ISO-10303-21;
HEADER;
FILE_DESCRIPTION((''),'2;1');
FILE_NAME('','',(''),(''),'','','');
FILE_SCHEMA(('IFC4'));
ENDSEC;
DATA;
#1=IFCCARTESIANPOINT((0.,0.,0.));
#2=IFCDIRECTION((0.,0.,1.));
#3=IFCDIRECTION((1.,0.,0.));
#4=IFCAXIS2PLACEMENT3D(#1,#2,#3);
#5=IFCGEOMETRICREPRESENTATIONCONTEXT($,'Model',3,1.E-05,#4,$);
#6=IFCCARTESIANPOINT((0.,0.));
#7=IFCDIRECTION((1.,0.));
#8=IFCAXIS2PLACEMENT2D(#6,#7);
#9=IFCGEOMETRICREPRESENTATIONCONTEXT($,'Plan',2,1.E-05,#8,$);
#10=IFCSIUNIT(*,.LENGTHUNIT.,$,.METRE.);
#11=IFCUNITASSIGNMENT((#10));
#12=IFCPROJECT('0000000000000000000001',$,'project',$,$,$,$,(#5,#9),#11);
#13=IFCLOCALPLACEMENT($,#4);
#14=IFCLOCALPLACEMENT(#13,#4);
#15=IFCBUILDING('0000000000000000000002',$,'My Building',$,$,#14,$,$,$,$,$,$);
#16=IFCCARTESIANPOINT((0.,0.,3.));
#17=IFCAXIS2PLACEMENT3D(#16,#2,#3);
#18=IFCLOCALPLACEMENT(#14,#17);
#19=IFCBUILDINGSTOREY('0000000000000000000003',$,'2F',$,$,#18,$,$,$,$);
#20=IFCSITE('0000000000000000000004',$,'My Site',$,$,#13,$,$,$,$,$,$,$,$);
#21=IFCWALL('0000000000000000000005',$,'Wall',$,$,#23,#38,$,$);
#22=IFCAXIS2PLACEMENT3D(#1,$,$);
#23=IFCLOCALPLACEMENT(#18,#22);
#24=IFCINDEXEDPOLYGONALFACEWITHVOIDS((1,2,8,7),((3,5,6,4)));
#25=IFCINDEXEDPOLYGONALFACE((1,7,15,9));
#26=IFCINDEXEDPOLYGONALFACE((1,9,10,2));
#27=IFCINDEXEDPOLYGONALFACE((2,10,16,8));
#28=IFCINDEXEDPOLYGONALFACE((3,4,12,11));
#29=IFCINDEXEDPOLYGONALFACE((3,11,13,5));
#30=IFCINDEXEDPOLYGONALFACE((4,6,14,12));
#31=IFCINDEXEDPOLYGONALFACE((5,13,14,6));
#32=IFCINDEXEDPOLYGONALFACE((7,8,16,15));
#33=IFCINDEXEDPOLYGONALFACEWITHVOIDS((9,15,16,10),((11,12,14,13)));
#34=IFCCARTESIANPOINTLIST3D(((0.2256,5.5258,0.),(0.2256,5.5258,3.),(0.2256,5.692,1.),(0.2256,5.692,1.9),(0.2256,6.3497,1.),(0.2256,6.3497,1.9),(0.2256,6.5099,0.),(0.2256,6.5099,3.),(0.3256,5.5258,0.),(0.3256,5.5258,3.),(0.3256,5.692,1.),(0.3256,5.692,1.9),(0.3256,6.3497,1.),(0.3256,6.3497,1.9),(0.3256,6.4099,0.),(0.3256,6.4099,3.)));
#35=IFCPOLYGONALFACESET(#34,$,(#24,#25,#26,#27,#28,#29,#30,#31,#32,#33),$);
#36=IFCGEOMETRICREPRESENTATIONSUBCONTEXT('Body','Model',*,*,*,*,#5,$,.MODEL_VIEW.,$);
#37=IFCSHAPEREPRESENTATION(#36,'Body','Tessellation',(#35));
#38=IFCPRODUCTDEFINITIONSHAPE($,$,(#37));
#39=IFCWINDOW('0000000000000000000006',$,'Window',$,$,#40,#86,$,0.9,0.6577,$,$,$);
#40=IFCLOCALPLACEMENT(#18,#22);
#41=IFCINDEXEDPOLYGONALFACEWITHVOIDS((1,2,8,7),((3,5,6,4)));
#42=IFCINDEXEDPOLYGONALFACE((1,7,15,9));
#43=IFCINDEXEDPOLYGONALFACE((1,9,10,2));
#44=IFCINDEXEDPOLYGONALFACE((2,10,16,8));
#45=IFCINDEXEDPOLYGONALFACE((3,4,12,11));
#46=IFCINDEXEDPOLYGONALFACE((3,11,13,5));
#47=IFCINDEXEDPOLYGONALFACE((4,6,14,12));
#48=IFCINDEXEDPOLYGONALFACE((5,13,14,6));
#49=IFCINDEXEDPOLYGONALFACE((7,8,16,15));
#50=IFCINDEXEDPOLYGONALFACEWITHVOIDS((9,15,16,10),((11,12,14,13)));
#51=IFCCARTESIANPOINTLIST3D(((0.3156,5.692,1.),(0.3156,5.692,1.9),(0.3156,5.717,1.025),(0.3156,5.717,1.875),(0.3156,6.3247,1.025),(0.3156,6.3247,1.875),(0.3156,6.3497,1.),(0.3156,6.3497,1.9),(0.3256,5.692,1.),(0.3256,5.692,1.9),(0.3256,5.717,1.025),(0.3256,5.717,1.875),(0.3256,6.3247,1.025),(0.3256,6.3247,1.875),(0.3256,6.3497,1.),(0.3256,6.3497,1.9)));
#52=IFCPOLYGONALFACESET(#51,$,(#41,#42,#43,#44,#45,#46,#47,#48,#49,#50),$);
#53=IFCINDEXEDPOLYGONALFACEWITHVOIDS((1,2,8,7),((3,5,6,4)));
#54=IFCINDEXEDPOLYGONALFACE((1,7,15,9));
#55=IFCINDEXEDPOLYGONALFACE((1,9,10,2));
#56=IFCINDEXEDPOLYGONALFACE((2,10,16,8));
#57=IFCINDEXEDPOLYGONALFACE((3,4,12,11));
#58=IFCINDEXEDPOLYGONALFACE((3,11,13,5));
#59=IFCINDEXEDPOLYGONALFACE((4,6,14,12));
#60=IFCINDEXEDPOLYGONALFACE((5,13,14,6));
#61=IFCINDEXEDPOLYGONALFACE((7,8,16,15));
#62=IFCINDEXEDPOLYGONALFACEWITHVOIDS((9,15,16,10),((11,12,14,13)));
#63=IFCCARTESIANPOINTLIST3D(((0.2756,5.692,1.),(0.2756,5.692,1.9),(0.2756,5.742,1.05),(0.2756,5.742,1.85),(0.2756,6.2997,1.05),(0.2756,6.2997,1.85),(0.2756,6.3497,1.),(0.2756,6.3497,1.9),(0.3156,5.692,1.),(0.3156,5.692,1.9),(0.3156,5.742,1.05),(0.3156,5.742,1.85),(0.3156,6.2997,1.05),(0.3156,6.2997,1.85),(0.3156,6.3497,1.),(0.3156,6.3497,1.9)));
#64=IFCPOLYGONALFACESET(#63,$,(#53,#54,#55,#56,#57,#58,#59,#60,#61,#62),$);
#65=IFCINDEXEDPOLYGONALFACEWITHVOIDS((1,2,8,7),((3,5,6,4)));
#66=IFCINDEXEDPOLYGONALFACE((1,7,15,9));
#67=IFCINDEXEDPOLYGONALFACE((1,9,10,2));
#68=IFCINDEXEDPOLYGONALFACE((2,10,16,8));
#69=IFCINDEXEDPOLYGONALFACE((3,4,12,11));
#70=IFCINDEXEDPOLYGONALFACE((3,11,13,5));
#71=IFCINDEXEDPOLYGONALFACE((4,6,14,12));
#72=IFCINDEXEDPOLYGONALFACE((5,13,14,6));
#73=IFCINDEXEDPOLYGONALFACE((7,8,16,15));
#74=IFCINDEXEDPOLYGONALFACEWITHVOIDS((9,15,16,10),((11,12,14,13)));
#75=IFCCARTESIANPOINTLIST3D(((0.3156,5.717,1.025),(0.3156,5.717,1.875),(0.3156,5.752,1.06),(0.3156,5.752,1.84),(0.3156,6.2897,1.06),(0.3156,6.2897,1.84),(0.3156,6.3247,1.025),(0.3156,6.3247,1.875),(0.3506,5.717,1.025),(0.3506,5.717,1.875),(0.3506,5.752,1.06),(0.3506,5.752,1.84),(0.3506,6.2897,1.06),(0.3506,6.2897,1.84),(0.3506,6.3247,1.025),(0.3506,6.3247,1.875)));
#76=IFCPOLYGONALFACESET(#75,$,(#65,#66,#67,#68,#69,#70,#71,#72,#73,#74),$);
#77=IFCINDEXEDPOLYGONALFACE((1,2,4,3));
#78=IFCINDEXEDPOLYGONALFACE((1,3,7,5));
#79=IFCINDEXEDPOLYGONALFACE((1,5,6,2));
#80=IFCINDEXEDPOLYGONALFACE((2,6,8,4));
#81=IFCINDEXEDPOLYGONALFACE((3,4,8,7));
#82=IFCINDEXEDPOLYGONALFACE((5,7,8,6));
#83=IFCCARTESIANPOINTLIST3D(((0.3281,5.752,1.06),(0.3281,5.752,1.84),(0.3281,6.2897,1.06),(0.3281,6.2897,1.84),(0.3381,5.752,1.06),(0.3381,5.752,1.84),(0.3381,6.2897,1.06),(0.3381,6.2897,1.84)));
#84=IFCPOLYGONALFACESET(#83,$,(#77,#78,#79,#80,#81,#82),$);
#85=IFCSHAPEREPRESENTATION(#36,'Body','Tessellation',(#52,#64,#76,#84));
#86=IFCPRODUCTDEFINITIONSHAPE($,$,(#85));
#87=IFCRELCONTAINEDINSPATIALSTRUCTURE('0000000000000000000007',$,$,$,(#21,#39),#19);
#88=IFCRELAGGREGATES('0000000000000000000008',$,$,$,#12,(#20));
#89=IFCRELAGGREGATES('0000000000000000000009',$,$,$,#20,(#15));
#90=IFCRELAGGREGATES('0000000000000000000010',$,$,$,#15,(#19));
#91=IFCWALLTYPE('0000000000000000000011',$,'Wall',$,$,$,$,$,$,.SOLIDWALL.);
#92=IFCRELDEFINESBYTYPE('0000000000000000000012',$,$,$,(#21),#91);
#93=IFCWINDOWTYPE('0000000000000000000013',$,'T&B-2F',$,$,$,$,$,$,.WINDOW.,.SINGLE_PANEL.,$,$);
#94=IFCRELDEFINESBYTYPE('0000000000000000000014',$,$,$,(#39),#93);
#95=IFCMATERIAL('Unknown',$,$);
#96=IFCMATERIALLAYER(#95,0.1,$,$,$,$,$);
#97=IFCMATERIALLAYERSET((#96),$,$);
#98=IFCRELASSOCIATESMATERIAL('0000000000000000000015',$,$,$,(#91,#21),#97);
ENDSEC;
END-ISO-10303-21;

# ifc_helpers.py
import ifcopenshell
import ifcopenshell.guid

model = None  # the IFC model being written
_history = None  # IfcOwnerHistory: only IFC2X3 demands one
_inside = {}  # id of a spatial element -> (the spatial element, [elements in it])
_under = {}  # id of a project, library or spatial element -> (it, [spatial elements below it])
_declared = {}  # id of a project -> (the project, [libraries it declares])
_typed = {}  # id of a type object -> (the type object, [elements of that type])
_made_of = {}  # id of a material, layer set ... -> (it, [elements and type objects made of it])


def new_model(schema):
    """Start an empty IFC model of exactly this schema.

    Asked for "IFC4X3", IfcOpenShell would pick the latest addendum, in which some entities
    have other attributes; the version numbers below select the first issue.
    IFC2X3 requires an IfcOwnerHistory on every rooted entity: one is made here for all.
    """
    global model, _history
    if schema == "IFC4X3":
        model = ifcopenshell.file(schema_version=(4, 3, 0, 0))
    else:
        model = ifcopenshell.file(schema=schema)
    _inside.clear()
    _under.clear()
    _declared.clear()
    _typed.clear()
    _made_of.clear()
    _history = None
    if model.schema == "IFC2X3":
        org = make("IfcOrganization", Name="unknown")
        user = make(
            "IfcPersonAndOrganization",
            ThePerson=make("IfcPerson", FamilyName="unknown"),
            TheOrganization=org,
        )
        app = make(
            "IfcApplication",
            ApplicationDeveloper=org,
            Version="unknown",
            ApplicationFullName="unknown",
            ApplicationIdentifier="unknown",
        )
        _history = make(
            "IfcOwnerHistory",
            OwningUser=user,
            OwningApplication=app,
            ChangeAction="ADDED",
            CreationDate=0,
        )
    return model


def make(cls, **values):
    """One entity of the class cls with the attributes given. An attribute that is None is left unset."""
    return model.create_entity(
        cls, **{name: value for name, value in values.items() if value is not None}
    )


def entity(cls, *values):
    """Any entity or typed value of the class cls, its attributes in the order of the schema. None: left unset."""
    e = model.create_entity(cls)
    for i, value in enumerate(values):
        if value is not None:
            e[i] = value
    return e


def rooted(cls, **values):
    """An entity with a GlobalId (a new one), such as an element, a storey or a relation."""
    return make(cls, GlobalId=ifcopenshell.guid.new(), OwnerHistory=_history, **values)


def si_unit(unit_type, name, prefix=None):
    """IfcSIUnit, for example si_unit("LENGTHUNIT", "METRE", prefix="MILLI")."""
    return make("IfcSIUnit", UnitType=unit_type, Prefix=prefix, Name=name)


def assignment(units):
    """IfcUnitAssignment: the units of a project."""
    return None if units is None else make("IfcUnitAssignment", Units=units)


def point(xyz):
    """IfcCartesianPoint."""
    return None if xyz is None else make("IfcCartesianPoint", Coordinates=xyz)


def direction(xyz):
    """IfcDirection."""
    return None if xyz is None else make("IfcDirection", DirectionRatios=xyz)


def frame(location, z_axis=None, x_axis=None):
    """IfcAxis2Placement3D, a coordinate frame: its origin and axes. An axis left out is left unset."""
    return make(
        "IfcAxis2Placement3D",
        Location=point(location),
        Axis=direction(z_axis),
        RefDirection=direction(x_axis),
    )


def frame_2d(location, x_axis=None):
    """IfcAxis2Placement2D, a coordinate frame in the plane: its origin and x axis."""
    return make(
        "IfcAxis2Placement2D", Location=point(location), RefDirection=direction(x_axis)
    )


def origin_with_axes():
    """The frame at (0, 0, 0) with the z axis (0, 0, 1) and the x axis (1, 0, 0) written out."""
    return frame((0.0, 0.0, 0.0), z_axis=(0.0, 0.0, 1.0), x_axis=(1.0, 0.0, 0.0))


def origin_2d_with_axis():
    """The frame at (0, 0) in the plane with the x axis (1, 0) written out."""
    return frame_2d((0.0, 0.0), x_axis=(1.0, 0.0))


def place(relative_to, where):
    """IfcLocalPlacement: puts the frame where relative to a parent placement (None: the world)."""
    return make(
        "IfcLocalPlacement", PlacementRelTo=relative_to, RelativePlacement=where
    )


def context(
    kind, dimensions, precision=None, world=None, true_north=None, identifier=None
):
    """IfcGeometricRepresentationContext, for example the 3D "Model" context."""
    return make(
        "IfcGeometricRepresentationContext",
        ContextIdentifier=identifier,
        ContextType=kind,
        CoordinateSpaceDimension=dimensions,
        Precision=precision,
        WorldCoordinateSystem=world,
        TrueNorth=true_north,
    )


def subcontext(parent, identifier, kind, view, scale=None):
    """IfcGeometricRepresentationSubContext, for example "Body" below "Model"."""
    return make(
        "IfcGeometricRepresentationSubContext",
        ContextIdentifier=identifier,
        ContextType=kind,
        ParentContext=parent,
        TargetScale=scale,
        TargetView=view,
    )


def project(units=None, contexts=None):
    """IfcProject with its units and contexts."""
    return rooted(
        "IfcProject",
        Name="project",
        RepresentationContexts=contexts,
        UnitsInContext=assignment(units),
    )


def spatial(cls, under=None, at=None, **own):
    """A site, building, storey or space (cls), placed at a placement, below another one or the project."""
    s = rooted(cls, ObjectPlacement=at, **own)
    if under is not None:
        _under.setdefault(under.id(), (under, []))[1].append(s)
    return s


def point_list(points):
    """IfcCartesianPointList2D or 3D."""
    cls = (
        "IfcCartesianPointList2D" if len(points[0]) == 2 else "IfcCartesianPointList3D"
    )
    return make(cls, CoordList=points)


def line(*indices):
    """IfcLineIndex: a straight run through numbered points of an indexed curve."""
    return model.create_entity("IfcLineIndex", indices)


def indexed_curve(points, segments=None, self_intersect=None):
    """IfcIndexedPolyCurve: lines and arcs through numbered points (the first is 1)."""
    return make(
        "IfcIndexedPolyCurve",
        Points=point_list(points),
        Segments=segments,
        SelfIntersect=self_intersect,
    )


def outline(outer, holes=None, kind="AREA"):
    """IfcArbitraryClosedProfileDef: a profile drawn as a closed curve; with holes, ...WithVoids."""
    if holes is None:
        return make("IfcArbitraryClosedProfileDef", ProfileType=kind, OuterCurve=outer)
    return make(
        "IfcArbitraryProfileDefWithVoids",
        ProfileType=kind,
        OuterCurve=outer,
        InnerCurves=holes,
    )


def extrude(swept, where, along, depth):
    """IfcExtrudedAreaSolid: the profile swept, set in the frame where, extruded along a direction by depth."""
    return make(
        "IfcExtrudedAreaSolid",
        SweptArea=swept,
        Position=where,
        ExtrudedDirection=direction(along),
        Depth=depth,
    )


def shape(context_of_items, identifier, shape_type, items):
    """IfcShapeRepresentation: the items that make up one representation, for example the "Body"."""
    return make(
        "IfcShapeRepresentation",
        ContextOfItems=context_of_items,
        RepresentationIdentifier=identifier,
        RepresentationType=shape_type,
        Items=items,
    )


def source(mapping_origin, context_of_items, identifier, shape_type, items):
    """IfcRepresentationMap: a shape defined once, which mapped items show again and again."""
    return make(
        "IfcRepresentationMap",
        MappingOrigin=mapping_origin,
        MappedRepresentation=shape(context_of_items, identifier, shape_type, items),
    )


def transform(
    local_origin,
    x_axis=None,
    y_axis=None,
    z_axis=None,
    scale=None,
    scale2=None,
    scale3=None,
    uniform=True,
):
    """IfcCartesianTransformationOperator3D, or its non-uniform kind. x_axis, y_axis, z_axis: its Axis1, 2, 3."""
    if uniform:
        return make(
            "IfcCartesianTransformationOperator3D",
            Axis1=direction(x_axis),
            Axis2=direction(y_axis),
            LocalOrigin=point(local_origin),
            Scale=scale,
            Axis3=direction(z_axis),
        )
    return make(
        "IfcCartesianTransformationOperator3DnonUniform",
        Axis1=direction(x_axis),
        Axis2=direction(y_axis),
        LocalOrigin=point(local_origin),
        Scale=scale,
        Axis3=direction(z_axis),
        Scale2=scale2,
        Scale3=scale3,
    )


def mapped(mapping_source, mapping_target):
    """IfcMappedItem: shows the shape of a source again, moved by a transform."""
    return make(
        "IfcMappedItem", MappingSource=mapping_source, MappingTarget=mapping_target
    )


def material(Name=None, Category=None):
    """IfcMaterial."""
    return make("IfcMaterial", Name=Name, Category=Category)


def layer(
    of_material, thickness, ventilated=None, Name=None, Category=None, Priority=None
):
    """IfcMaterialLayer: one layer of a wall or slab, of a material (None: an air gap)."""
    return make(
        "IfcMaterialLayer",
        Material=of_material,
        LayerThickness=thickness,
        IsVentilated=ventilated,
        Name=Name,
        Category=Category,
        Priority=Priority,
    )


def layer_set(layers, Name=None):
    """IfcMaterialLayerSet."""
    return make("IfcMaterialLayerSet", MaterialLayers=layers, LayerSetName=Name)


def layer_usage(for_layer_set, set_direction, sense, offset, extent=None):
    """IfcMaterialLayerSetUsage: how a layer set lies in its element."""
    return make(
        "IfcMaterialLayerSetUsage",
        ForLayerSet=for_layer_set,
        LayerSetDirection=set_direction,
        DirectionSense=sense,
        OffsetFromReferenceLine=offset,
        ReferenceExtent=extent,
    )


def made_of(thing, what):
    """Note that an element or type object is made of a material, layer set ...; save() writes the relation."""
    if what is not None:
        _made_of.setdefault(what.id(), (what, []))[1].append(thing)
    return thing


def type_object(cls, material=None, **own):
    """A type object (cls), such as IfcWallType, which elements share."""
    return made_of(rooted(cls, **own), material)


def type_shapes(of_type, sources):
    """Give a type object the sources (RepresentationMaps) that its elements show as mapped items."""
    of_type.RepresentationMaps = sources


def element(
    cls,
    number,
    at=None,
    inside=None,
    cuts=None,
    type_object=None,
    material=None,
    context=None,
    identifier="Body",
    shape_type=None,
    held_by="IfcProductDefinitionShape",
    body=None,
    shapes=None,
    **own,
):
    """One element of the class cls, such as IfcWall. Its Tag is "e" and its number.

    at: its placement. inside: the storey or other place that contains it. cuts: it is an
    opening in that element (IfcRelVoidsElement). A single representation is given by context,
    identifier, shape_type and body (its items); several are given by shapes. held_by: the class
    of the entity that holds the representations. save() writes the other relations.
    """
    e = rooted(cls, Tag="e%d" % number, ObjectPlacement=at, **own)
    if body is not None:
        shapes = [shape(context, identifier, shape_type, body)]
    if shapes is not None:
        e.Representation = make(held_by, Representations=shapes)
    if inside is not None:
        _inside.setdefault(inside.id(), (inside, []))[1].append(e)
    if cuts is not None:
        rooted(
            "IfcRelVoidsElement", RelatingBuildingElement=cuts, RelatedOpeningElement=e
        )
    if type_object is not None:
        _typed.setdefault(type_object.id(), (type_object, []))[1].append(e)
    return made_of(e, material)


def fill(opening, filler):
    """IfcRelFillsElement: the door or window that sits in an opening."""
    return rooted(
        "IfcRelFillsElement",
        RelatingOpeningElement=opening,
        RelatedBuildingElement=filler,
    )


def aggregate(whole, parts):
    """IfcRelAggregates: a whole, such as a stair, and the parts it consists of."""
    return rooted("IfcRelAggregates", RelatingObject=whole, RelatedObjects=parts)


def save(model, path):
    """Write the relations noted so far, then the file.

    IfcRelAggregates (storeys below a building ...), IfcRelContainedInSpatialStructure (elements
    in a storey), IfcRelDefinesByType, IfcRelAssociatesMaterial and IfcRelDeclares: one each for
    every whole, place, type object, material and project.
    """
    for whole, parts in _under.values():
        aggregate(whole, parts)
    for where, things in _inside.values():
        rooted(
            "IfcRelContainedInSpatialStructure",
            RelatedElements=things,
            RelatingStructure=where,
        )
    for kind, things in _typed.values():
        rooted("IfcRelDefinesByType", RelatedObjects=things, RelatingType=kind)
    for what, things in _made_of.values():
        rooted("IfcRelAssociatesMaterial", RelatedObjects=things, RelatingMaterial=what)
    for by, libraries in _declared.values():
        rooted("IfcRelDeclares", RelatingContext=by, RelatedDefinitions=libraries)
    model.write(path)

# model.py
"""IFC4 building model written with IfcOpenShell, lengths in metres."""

from ifc_helpers import new_model, entity, si_unit, frame, origin_with_axes, origin_2d_with_axis, place, context, subcontext, project, spatial, line, indexed_curve, outline, extrude, shape, source, transform, mapped, material, layer, layer_set, layer_usage, type_object, type_shapes, element, fill, save


model = new_model("IFC4")

# Units and contexts
model_context = context("Model", 3, precision=1e-05, world=origin_with_axes())
plan_context = context("Plan", 2, precision=1e-05, world=origin_2d_with_axis())
body_context_1 = subcontext(model_context, "Body", "Model", "MODEL_VIEW")
body_context_2 = subcontext(plan_context, "Body", "Plan", "PLAN_VIEW")
ifc_project = project(units=[si_unit("LENGTHUNIT", "METRE")], contexts=[model_context, plan_context])

# Site, building, storey
site_placement = place(None, origin_with_axes())
site = spatial("IfcSite", under=ifc_project, at=site_placement, Name="My Site")
building_placement = place(site_placement, origin_with_axes())
building = spatial("IfcBuilding", under=site, at=building_placement, Name="My Building")
storey_placement = place(building_placement, frame((0.0, 0.0, 3.0), z_axis=(0.0, 0.0, 1.0), x_axis=(1.0, 0.0, 0.0)))
storey = spatial("IfcBuildingStorey", under=building, at=storey_placement, Name="2F")

# Shared definitions
ifc_material = material(Name="Unknown")
ifc_layer = layer(ifc_material, 0.1)
ifc_layer_set = layer_set([ifc_layer])
wall_type = type_object("IfcWallType", Name="Wall", PredefinedType="SOLIDWALL", material=ifc_layer_set)

# Wall, opening, window
ifc_layer_usage_1 = layer_usage(ifc_layer_set, "AXIS2", "POSITIVE", 0.0)
wall_1_placement = place(storey_placement, frame((0.2256, 6.5099, 0.0), z_axis=(0.0, 0.0, 1.0), x_axis=(0.0, -1.0, 0.0)))
wall_1 = element("IfcWall", 1, at=wall_1_placement, inside=storey, type_object=wall_type, material=ifc_layer_usage_1, Name="Wall", context=body_context_1, shape_type="SweptSolid", body=[
    extrude(outline(indexed_curve([(0.0, 0.0), (0.1, 0.1), (0.9842, 0.1), (0.9842, 0.0)], segments=[line(1, 2, 3, 4, 1)])), origin_with_axes(), (0.0, 0.0, 1.0), 3.0),
])
shared_shape_1 = source(origin_with_axes(), body_context_1, "Body", "SweptSolid", [
    extrude(outline(indexed_curve([(0.0, 0.0), (0.6577, 0.0), (0.6577, 0.9), (0.0, 0.9)], segments=[line(1, 2, 3, 4, 1)])), frame((0.0, -0.6, 0.0), z_axis=(0.0, -1.0, 0.0), x_axis=(1.0, 0.0, 0.0)), (0.0, 0.0, -1.0), 1.2),
])
opening_1_placement = place(wall_1_placement, frame((0.1602, 0.0, 1.0), z_axis=(0.0, 0.0, 1.0), x_axis=(1.0, 0.0, 0.0)))
opening_1 = element("IfcOpeningElement", 2, at=opening_1_placement, cuts=wall_1, PredefinedType="OPENING", context=body_context_1, shape_type="MappedRepresentation", body=[
    mapped(shared_shape_1, transform((0.0, 0.0, 0.0), x_axis=(1.0, 0.0, 0.0), y_axis=(0.0, 1.0, 0.0), z_axis=(0.0, 0.0, 1.0), scale=1.0)),
])
window_type_1 = type_object("IfcWindowType", Name="T&B-2F", PartitioningType="SINGLE_PANEL", PredefinedType="WINDOW")
shared_shape_2 = source(origin_with_axes(), body_context_1, "Body", "SweptSolid", [
    extrude(outline(indexed_curve([(0.0, 0.0), (0.6577, 0.0), (0.6577, 0.9), (0.0, 0.9)], segments=[line(1, 2, 3, 4, 1)]), holes=[indexed_curve([(0.025, 0.025), (0.6327, 0.025), (0.6327, 0.875), (0.025, 0.875)], segments=[line(1, 2, 3, 4, 1)])]), frame((0.0, 0.09, 0.0), z_axis=(0.0, -1.0, 0.0), x_axis=(1.0, 0.0, 0.0)), (0.0, 0.0, -1.0), 0.01),
    extrude(outline(indexed_curve([(0.0, 0.0), (0.6577, 0.0), (0.6577, 0.9), (0.0, 0.9)], segments=[line(1, 2, 3, 4, 1)]), holes=[indexed_curve([(0.05, 0.05), (0.6077, 0.05), (0.6077, 0.85), (0.05, 0.85)], segments=[line(1, 2, 3, 4, 1)])]), frame((0.0, 0.05, 0.0), z_axis=(0.0, -1.0, 0.0), x_axis=(1.0, 0.0, 0.0)), (0.0, 0.0, -1.0), 0.04),
    extrude(outline(indexed_curve([(0.0, 0.0), (0.6077, 0.0), (0.6077, 0.85), (0.0, 0.85)], segments=[line(1, 2, 3, 4, 1)]), holes=[indexed_curve([(0.035, 0.035), (0.5727, 0.035), (0.5727, 0.815), (0.035, 0.815)], segments=[line(1, 2, 3, 4, 1)])]), frame((0.025, 0.09, 0.025), z_axis=(0.0, -1.0, 0.0), x_axis=(1.0, 0.0, 0.0)), (0.0, 0.0, -1.0), 0.035),
    extrude(outline(indexed_curve([(0.035, 0.035), (0.5727, 0.035), (0.5727, 0.815), (0.035, 0.815)], segments=[line(1, 2, 3, 4, 1)])), frame((0.025, 0.1025, 0.025), z_axis=(0.0, -1.0, 0.0), x_axis=(1.0, 0.0, 0.0)), (0.0, 0.0, -1.0), 0.01),
])
shared_shape_3 = source(origin_with_axes(), body_context_2, "Body", "Curve2D", [
    entity("IfcIndexedPolyCurve", entity("IfcCartesianPointList2D", [[0.05, 0.05], [0.6077, 0.05]])),
    entity("IfcIndexedPolyCurve", entity("IfcCartesianPointList2D", [[0.0, 0.1], [0.025, 0.1], [0.025, 0.09], [0.05, 0.09], [0.05, 0.05], [0.0, 0.05]]), [entity("IfcLineIndex", [1, 2, 3, 4, 5, 6, 1])]),
    entity("IfcIndexedPolyCurve", entity("IfcCartesianPointList2D", [[0.6577, 0.1], [0.6327, 0.1], [0.6327, 0.09], [0.6077, 0.09], [0.6077, 0.05], [0.6577, 0.05]]), [entity("IfcLineIndex", [1, 2, 3, 4, 5, 6, 1])]),
    entity("IfcIndexedPolyCurve", entity("IfcCartesianPointList2D", [[0.025, 0.09], [0.06, 0.09], [0.06, 0.125], [0.025, 0.125]]), [entity("IfcLineIndex", [1, 2, 3, 4, 1])]),
    entity("IfcIndexedPolyCurve", entity("IfcCartesianPointList2D", [[0.6327, 0.09], [0.5977, 0.09], [0.5977, 0.125], [0.6327, 0.125]]), [entity("IfcLineIndex", [1, 2, 3, 4, 1])]),
    entity("IfcIndexedPolyCurve", entity("IfcCartesianPointList2D", [[0.06, 0.09], [0.5977, 0.09]])),
    entity("IfcIndexedPolyCurve", entity("IfcCartesianPointList2D", [[0.06, 0.125], [0.5977, 0.125]])),
    entity("IfcIndexedPolyCurve", entity("IfcCartesianPointList2D", [[0.06, 0.1075], [0.5977, 0.1075]])),
])
type_shapes(window_type_1, [shared_shape_2, shared_shape_3])
window_1_placement = place(opening_1_placement, frame((0.0, 0.0, 0.0), z_axis=(0.0, 0.0, 1.0), x_axis=(1.0, 0.0, 0.0)))
window_1 = element("IfcWindow", 3, at=window_1_placement, inside=storey, type_object=window_type_1, Name="Window", OverallHeight=0.9, OverallWidth=0.6577, shapes=[
    shape(body_context_1, "Body", "MappedRepresentation", [mapped(shared_shape_2, transform((0.0, 0.0, 0.0), x_axis=(1.0, 0.0, 0.0), y_axis=(0.0, 1.0, 0.0), z_axis=(0.0, 0.0, 1.0), scale=1.0))]),
    shape(body_context_2, "Body", "MappedRepresentation", [mapped(shared_shape_3, transform((0.0, 0.0, 0.0), x_axis=(1.0, 0.0, 0.0), y_axis=(0.0, 1.0, 0.0), z_axis=(0.0, 0.0, 1.0), scale=1.0))]),
])
fill(opening_1, window_1)

save(model, "model.ifc")
